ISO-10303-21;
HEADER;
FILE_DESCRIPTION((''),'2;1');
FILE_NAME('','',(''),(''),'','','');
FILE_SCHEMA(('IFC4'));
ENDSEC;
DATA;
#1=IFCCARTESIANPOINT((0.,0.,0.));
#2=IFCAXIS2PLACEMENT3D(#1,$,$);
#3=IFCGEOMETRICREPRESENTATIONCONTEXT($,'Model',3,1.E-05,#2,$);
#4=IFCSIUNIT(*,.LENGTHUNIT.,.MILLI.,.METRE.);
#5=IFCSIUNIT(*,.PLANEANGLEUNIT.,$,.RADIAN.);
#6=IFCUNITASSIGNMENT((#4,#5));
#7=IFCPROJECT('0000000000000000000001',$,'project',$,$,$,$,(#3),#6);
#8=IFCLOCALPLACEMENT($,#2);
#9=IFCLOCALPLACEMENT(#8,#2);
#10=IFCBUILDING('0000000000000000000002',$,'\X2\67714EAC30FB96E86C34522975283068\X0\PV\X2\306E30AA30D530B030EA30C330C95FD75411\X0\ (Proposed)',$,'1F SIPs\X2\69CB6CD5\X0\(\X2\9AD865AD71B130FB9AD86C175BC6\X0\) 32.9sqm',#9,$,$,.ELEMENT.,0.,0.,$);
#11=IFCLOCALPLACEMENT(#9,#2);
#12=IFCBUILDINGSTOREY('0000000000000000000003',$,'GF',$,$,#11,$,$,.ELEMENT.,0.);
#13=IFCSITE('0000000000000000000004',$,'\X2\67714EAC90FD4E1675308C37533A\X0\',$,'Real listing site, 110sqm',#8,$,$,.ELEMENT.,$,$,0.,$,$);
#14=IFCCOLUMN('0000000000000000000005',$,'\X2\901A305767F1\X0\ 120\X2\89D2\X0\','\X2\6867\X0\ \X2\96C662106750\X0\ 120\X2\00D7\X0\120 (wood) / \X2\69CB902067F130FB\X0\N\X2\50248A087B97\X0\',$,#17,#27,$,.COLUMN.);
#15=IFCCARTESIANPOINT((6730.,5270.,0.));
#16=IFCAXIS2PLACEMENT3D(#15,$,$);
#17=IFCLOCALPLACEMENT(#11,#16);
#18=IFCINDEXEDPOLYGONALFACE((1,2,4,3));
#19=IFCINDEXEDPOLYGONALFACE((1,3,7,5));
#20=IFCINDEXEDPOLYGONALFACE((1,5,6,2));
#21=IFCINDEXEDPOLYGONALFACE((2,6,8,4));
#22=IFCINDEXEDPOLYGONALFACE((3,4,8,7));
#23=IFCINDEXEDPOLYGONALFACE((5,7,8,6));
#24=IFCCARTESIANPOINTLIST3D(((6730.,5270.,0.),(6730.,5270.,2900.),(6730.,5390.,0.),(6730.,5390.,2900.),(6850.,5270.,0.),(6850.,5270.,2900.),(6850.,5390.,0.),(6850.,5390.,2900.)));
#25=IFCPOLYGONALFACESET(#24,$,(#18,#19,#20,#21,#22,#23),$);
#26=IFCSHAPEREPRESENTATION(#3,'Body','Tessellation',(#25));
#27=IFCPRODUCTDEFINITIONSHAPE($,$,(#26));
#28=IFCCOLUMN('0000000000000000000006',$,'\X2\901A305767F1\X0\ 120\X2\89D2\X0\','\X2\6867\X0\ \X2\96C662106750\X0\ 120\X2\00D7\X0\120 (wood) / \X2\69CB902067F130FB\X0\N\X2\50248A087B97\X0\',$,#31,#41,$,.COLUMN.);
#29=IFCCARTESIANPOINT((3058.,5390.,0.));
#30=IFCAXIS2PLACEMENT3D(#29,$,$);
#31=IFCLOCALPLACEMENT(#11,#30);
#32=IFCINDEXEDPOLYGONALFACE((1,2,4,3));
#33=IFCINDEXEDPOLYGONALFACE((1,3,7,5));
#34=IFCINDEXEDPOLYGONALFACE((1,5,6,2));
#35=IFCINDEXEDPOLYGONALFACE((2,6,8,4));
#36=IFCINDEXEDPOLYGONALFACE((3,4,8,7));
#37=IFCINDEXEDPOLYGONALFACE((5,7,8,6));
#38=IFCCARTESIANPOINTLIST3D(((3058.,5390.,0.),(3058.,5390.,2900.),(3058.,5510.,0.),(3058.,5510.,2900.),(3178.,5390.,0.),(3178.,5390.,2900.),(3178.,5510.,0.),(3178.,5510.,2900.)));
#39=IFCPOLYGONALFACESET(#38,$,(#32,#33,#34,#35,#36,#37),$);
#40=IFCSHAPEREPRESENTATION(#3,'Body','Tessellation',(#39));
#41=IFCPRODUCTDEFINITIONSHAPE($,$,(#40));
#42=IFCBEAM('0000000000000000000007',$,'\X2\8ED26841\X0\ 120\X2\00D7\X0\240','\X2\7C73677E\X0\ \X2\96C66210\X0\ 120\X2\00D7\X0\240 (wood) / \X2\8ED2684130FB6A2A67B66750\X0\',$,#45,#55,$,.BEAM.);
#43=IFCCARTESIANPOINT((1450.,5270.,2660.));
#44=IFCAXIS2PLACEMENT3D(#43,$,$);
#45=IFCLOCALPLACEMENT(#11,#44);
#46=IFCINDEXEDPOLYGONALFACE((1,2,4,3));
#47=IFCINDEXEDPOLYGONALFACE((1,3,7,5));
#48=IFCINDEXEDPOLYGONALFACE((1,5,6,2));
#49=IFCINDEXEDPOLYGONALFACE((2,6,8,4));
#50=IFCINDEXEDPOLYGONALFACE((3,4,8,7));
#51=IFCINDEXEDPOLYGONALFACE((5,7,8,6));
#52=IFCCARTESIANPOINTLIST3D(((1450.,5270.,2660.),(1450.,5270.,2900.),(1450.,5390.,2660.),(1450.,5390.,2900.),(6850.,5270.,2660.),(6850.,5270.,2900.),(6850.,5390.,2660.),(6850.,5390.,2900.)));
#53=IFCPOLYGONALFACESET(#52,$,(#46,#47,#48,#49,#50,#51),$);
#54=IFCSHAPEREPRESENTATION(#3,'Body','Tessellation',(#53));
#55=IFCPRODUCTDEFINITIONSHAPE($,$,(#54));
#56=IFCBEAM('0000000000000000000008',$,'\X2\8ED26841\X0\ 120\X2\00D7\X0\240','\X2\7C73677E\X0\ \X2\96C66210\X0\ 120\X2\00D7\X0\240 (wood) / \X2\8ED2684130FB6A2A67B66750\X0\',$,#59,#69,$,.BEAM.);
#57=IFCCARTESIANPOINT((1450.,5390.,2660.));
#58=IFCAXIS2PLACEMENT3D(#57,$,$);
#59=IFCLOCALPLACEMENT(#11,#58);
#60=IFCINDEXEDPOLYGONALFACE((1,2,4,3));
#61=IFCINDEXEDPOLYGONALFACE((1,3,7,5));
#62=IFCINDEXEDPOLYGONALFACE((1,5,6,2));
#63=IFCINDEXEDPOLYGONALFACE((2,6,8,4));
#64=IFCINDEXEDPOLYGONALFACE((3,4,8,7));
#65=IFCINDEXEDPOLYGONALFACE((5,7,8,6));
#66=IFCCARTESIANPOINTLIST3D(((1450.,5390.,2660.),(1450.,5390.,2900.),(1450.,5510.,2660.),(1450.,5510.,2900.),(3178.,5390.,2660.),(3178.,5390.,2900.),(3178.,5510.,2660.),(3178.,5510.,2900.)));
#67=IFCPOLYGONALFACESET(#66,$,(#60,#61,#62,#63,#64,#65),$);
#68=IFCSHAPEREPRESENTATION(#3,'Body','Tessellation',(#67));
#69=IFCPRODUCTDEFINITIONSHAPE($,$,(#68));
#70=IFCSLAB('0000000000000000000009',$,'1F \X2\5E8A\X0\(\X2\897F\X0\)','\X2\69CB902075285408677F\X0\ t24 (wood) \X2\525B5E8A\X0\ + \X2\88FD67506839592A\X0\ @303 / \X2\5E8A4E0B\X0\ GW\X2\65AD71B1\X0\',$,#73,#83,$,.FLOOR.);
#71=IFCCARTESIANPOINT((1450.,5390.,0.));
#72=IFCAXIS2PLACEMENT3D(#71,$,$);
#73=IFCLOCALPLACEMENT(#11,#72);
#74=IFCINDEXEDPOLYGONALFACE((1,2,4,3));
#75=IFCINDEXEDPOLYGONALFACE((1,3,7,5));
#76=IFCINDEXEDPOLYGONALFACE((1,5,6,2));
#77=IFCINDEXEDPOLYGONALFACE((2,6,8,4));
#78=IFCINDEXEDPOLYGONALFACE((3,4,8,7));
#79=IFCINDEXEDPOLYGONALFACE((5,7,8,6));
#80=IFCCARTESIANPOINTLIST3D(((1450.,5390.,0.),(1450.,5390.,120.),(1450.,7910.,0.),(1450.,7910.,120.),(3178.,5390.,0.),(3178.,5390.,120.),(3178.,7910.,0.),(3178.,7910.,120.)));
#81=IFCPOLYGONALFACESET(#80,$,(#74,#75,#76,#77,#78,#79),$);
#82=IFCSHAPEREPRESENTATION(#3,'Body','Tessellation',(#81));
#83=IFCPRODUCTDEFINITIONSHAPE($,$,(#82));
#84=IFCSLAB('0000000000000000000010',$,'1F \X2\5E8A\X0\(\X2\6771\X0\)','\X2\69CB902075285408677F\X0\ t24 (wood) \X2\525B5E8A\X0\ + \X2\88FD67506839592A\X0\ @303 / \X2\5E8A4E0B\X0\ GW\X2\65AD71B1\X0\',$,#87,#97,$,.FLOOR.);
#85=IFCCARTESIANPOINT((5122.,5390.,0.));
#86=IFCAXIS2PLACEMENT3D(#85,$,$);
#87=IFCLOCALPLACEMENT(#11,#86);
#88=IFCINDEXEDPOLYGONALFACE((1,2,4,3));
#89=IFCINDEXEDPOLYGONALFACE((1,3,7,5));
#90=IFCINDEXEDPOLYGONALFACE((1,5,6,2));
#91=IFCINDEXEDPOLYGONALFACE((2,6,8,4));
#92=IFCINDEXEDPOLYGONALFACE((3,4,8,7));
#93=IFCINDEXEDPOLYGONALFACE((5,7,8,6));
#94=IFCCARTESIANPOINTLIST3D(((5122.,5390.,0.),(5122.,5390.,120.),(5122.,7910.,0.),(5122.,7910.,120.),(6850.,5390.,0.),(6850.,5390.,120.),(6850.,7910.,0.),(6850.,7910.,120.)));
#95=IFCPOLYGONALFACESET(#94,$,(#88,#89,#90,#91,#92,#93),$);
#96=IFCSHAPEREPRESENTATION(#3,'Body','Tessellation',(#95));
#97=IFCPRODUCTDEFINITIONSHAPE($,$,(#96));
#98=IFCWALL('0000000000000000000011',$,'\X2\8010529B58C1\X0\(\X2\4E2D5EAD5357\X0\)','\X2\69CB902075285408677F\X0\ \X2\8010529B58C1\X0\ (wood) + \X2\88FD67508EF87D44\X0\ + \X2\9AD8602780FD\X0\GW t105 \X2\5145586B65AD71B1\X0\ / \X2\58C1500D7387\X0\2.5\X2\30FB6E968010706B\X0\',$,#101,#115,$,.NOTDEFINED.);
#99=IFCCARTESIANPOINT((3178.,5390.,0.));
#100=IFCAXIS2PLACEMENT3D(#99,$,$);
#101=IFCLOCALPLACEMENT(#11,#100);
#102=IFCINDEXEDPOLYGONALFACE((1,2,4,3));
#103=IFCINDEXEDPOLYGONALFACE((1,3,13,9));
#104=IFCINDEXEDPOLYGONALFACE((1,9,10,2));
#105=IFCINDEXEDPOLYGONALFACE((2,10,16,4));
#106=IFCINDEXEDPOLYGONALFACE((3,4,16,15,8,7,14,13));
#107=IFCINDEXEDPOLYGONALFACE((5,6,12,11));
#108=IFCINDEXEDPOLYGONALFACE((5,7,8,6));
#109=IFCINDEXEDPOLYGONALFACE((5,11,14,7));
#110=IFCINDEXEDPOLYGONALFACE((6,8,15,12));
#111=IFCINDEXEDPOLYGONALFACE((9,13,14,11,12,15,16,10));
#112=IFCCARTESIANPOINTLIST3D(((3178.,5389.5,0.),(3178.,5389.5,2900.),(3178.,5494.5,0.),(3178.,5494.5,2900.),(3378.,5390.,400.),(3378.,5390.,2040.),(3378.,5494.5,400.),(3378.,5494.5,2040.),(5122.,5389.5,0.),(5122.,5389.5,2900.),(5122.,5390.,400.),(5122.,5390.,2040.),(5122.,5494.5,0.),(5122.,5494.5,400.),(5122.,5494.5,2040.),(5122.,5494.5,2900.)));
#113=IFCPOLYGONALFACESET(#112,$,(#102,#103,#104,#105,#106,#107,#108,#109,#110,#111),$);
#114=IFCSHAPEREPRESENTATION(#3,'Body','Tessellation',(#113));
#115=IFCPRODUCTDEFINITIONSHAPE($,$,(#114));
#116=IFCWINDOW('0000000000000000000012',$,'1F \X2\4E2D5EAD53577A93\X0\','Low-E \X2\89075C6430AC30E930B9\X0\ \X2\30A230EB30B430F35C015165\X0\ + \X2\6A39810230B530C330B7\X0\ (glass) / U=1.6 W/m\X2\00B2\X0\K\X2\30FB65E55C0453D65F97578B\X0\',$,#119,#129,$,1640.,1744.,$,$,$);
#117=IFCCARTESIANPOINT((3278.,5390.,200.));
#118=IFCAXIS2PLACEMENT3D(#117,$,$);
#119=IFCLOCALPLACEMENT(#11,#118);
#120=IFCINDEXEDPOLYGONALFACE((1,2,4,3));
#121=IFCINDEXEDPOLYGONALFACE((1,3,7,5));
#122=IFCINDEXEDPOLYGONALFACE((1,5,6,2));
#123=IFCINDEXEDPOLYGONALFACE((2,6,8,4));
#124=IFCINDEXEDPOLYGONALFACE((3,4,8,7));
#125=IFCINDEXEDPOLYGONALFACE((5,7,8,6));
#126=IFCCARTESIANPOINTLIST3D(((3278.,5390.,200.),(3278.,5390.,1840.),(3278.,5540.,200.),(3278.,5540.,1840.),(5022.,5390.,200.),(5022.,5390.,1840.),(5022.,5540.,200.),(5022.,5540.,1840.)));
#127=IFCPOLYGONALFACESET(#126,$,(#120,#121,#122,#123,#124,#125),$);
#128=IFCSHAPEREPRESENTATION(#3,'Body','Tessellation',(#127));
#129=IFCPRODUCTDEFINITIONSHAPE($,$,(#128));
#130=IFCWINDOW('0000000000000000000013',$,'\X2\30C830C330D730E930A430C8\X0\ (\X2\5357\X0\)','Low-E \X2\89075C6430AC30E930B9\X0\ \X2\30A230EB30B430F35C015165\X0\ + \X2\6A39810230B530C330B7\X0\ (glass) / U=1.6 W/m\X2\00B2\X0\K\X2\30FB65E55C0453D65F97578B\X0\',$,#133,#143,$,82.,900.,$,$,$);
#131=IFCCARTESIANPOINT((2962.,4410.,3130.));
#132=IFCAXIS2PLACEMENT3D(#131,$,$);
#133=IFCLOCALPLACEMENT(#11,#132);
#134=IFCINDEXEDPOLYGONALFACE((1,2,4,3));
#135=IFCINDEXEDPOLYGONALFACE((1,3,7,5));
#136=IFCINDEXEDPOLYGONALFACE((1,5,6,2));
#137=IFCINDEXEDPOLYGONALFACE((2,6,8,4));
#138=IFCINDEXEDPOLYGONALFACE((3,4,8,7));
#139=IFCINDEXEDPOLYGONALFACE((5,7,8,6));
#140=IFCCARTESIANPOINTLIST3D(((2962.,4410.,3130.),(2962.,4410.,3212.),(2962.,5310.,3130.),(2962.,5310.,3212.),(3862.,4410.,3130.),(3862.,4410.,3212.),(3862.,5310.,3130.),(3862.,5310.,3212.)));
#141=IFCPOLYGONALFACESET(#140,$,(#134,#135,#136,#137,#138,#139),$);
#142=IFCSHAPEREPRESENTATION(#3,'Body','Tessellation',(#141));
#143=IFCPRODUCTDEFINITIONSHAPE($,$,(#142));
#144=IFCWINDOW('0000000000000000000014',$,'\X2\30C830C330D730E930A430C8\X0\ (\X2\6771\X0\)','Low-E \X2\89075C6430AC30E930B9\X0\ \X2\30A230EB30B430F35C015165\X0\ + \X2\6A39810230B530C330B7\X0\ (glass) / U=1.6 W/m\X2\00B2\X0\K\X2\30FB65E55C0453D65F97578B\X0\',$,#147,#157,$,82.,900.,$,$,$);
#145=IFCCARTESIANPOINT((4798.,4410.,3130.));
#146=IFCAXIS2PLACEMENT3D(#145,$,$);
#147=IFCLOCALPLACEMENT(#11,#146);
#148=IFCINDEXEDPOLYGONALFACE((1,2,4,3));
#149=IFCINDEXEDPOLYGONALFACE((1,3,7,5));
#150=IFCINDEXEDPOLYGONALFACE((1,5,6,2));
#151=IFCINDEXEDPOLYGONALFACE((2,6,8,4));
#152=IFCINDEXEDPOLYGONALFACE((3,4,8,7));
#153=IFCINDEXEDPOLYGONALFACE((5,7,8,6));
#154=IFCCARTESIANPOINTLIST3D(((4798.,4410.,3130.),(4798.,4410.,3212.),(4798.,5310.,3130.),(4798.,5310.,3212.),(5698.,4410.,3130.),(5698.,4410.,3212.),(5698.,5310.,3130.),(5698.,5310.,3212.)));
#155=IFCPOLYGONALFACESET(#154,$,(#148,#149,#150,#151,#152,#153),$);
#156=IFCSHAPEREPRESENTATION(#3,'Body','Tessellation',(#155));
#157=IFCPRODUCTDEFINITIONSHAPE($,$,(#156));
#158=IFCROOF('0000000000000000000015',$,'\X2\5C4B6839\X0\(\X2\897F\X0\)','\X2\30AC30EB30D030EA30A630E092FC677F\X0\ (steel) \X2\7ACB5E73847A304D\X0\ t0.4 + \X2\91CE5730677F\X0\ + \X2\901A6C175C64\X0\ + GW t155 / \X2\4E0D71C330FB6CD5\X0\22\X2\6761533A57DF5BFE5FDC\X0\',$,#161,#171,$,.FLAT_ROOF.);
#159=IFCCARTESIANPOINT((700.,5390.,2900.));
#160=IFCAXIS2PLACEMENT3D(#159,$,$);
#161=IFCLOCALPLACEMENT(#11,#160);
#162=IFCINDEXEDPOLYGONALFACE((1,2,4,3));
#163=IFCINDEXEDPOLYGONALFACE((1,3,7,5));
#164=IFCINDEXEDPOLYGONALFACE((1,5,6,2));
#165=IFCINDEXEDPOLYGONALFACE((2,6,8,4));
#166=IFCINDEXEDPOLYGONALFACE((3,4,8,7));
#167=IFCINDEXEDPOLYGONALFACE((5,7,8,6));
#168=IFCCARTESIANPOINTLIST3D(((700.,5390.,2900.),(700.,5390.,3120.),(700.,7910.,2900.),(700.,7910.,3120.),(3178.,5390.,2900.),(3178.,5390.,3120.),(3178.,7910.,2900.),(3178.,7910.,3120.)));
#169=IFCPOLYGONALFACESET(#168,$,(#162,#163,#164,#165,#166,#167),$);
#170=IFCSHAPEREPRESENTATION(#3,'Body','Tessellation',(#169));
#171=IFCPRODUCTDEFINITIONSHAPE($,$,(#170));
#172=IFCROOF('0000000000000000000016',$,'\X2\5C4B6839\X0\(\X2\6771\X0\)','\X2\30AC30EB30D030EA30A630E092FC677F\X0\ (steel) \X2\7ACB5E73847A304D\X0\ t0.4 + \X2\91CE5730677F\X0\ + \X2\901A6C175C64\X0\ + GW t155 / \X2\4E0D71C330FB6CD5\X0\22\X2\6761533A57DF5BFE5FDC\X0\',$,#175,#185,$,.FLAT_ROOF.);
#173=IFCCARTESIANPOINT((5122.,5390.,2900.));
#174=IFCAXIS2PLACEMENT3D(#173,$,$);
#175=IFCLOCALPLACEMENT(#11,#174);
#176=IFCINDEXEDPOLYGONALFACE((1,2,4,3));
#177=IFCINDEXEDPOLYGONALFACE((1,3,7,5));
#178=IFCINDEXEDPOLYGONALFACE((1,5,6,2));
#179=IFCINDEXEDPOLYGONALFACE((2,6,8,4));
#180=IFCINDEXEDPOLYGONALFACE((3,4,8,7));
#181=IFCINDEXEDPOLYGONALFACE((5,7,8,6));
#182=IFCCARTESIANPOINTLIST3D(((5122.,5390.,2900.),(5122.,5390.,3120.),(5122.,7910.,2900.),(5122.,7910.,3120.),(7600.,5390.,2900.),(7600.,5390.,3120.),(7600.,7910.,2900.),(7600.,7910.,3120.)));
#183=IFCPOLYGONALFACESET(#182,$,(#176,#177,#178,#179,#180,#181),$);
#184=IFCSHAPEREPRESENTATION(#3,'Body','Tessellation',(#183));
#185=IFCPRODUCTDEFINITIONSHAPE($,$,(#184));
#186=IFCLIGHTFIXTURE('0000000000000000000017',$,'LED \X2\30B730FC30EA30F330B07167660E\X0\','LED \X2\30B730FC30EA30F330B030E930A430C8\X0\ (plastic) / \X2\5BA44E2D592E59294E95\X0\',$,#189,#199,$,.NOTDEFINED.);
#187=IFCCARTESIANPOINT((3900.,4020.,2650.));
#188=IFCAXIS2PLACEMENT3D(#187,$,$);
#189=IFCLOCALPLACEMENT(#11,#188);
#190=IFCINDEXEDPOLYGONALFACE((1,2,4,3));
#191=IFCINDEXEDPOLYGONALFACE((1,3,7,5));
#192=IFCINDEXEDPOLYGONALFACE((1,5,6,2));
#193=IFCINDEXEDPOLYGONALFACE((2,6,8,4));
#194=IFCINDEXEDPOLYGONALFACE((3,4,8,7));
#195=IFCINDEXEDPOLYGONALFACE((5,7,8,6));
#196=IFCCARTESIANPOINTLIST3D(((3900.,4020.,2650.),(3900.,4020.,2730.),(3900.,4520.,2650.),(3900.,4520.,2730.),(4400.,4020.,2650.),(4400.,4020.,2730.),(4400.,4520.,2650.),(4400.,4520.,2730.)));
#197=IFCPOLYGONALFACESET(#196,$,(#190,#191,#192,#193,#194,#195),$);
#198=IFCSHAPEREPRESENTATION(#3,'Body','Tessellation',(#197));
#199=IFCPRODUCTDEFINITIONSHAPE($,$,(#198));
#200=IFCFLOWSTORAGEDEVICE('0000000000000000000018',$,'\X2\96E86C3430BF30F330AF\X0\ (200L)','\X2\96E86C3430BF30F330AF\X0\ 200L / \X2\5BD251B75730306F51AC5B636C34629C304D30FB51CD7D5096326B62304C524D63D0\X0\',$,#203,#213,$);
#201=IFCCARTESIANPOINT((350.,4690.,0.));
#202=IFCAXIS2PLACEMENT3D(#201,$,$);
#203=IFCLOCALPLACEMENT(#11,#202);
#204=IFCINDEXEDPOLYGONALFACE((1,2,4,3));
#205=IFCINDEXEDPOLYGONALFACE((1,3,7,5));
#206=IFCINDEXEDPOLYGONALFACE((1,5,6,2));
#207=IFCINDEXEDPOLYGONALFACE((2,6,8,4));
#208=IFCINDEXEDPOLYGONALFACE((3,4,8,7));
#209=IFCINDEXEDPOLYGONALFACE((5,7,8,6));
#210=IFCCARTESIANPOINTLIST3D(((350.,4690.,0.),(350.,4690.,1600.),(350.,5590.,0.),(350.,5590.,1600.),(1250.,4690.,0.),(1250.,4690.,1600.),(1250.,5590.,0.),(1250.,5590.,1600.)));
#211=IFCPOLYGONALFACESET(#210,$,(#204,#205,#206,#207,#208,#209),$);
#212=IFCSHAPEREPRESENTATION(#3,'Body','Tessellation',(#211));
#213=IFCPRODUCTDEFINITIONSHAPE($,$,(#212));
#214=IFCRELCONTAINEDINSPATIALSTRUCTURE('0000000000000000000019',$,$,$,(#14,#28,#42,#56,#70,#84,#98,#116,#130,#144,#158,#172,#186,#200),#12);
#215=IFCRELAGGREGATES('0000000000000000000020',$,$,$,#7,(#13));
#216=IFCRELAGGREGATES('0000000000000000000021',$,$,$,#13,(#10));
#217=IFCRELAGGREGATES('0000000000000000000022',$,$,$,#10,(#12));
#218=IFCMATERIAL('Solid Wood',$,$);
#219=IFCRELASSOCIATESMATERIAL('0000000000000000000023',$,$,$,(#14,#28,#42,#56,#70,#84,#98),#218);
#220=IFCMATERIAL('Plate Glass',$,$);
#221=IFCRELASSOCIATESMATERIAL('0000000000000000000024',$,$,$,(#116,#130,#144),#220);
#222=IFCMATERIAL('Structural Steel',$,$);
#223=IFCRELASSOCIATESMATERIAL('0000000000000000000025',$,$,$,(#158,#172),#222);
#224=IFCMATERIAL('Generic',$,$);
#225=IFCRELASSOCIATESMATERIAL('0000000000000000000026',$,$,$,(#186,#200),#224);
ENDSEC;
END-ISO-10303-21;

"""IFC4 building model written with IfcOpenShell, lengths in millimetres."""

from ifc_helpers import new_model, si_unit, frame, frame_2d, origin, place, context, project, spatial, rectangle, extrude, material, element, fill, save


model = new_model("IFC4")

# Units and contexts
model_context = context("Model", 3, precision=1e-05, world=origin())
ifc_project = project(units=[si_unit("LENGTHUNIT", "METRE", prefix="MILLI"), si_unit("PLANEANGLEUNIT", "RADIAN")], contexts=[model_context])

# Site, building, storey
site_placement = place(None, origin())
site = spatial("IfcSite", under=ifc_project, at=site_placement, Name="東京都世田谷区", ObjectType="Real listing site, 110sqm", CompositionType="ELEMENT", RefElevation=0.0)
building_placement = place(site_placement, origin())
building = spatial("IfcBuilding", under=site, at=building_placement, Name="東京・雨水利用とPVのオフグリッド志向 (Proposed)", ObjectType="1F SIPs構法(高断熱・高気密) 32.9sqm", CompositionType="ELEMENT", ElevationOfRefHeight=0.0, ElevationOfTerrain=0.0)
storey_placement = place(building_placement, origin())
storey = spatial("IfcBuildingStorey", under=building, at=storey_placement, Name="GF", CompositionType="ELEMENT", Elevation=0.0)

# Columns
ifc_material_1 = material(Name="Solid Wood")
column_1_placement = place(storey_placement, frame((6730.0, 5270.0, 0.0)))
element("IfcColumn", 1, at=column_1_placement, inside=storey, material=ifc_material_1, Name="通し柱 120角", Description="桧 集成材 120×120 (wood) / 構造柱・N値計算", PredefinedType="COLUMN", context=model_context, shape_type="SweptSolid", body=[
    extrude(rectangle(XDim=120.0, YDim=120.0, at=frame_2d((60.0, 60.0))), frame((6730.0, 5270.0, 0.0)), (0.0, 0.0, 1.0), 2900.0),
])
column_2_placement = place(storey_placement, frame((3058.0, 5390.0, 0.0)))
element("IfcColumn", 2, at=column_2_placement, inside=storey, material=ifc_material_1, Name="通し柱 120角", Description="桧 集成材 120×120 (wood) / 構造柱・N値計算", PredefinedType="COLUMN", context=model_context, shape_type="SweptSolid", body=[
    extrude(rectangle(XDim=120.0, YDim=120.0, at=frame_2d((60.0, 60.0))), frame((3058.0, 5390.0, 0.0)), (0.0, 0.0, 1.0), 2900.0),
])

# Beams
beam_1_placement = place(storey_placement, frame((1450.0, 5270.0, 2660.0)))
element("IfcBeam", 3, at=beam_1_placement, inside=storey, material=ifc_material_1, Name="軒桁 120×240", Description="米松 集成 120×240 (wood) / 軒桁・横架材", PredefinedType="BEAM", context=model_context, shape_type="SweptSolid", body=[
    extrude(rectangle(XDim=5400.0, YDim=120.0, at=frame_2d((2700.0, 60.0))), frame((1450.0, 5270.0, 2660.0)), (0.0, 0.0, 1.0), 240.0),
])
beam_2_placement = place(storey_placement, frame((1450.0, 5390.0, 2660.0)))
element("IfcBeam", 4, at=beam_2_placement, inside=storey, material=ifc_material_1, Name="軒桁 120×240", Description="米松 集成 120×240 (wood) / 軒桁・横架材", PredefinedType="BEAM", context=model_context, shape_type="SweptSolid", body=[
    extrude(rectangle(XDim=1728.0, YDim=120.0, at=frame_2d((864.0, 60.0))), frame((1450.0, 5390.0, 2660.0)), (0.0, 0.0, 1.0), 240.0),
])

# Slabs
slab_1_placement = place(storey_placement, frame((1450.0, 5390.0, 0.0)))
element("IfcSlab", 5, at=slab_1_placement, inside=storey, material=ifc_material_1, Name="1F 床(西)", Description="構造用合板 t24 (wood) 剛床 + 製材根太 @303 / 床下 GW断熱", PredefinedType="FLOOR", context=model_context, shape_type="SweptSolid", body=[
    extrude(rectangle(XDim=1728.0, YDim=2520.0, at=frame_2d((864.0, 1260.0))), frame((1450.0, 5390.0, 0.0)), (0.0, 0.0, 1.0), 120.0),
])
slab_2_placement = place(storey_placement, frame((5122.0, 5390.0, 0.0)))
element("IfcSlab", 6, at=slab_2_placement, inside=storey, material=ifc_material_1, Name="1F 床(東)", Description="構造用合板 t24 (wood) 剛床 + 製材根太 @303 / 床下 GW断熱", PredefinedType="FLOOR", context=model_context, shape_type="SweptSolid", body=[
    extrude(rectangle(XDim=1728.0, YDim=2520.0, at=frame_2d((864.0, 1260.0))), frame((5122.0, 5390.0, 0.0)), (0.0, 0.0, 1.0), 120.0),
])

# Wall, opening, window
wall_1_placement = place(storey_placement, frame((3178.0, 5390.0, 0.0)))
wall_1 = element("IfcWall", 7, at=wall_1_placement, inside=storey, material=ifc_material_1, Name="耐力壁(中庭南)", Description="構造用合板 耐力壁 (wood) + 製材軸組 + 高性能GW t105 充填断熱 / 壁倍率2.5・準耐火", PredefinedType="NOTDEFINED", context=model_context, shape_type="SweptSolid", body=[
    extrude(rectangle(XDim=1944.0, YDim=105.0, at=frame_2d((972.0, 52.0))), frame((3178.0, 5390.0, 0.0)), (0.0, 0.0, 1.0), 2900.0),
])
opening_placement = place(storey_placement, frame((3278.0, 5390.0, 200.0)))
opening = element("IfcOpeningElement", 8, at=opening_placement, cuts=wall_1, PredefinedType="NOTDEFINED", context=model_context, shape_type="SweptSolid", body=[
    extrude(rectangle(XDim=1744.0, YDim=150.0, at=frame_2d((872.0, 75.0))), frame((3278.0, 5390.0, 200.0)), (0.0, 0.0, 1.0), 1640.0),
])
ifc_material_2 = material(Name="Plate Glass")
window_1_placement = place(storey_placement, frame((3278.0, 5390.0, 200.0)))
window_1 = element("IfcWindow", 9, at=window_1_placement, inside=storey, material=ifc_material_2, Name="1F 中庭南窓", Description="Low-E 複層ガラス アルゴン封入 + 樹脂サッシ (glass) / U=1.6 W/m²K・日射取得型", OverallHeight=1640.0, OverallWidth=1744.0, context=model_context, shape_type="SweptSolid", body=[
    extrude(rectangle(XDim=1744.0, YDim=150.0, at=frame_2d((872.0, 75.0))), frame((3278.0, 5390.0, 200.0)), (0.0, 0.0, 1.0), 1640.0),
])
fill(opening, window_1)

# Windows
window_2_placement = place(storey_placement, frame((2962.0, 4410.0, 3130.0)))
element("IfcWindow", 10, at=window_2_placement, inside=storey, material=ifc_material_2, Name="トップライト (南)", Description="Low-E 複層ガラス アルゴン封入 + 樹脂サッシ (glass) / U=1.6 W/m²K・日射取得型", OverallHeight=82.0, OverallWidth=900.0, context=model_context, shape_type="SweptSolid", body=[
    extrude(rectangle(XDim=900.0, YDim=900.0, at=frame_2d((450.0, 450.0))), frame((2962.0, 4410.0, 3130.0)), (0.0, 0.0, 1.0), 82.0),
])
window_3_placement = place(storey_placement, frame((4798.0, 4410.0, 3130.0)))
element("IfcWindow", 11, at=window_3_placement, inside=storey, material=ifc_material_2, Name="トップライト (東)", Description="Low-E 複層ガラス アルゴン封入 + 樹脂サッシ (glass) / U=1.6 W/m²K・日射取得型", OverallHeight=82.0, OverallWidth=900.0, context=model_context, shape_type="SweptSolid", body=[
    extrude(rectangle(XDim=900.0, YDim=900.0, at=frame_2d((450.0, 450.0))), frame((4798.0, 4410.0, 3130.0)), (0.0, 0.0, 1.0), 82.0),
])

# Roofs
ifc_material_3 = material(Name="Structural Steel")
roof_1_placement = place(storey_placement, frame((700.0, 5390.0, 2900.0)))
element("IfcRoof", 12, at=roof_1_placement, inside=storey, material=ifc_material_3, Name="屋根(西)", Description="ガルバリウム鋼板 (steel) 立平葺き t0.4 + 野地板 + 通気層 + GW t155 / 不燃・法22条区域対応", PredefinedType="FLAT_ROOF", context=model_context, shape_type="SweptSolid", body=[
    extrude(rectangle(XDim=2478.0, YDim=2520.0, at=frame_2d((1239.0, 1260.0))), frame((700.0, 5390.0, 2900.0)), (0.0, 0.0, 1.0), 220.0),
])
roof_2_placement = place(storey_placement, frame((5122.0, 5390.0, 2900.0)))
element("IfcRoof", 13, at=roof_2_placement, inside=storey, material=ifc_material_3, Name="屋根(東)", Description="ガルバリウム鋼板 (steel) 立平葺き t0.4 + 野地板 + 通気層 + GW t155 / 不燃・法22条区域対応", PredefinedType="FLAT_ROOF", context=model_context, shape_type="SweptSolid", body=[
    extrude(rectangle(XDim=2478.0, YDim=2520.0, at=frame_2d((1239.0, 1260.0))), frame((5122.0, 5390.0, 2900.0)), (0.0, 0.0, 1.0), 220.0),
])

# Light fixture
ifc_material_4 = material(Name="Generic")
light_fixture_placement = place(storey_placement, frame((3900.0, 4020.0, 2650.0)))
element("IfcLightFixture", 14, at=light_fixture_placement, inside=storey, material=ifc_material_4, Name="LED シーリング照明", Description="LED シーリングライト (plastic) / 室中央天井", PredefinedType="NOTDEFINED", context=model_context, shape_type="SweptSolid", body=[
    extrude(rectangle(XDim=500.0, YDim=500.0, at=frame_2d((250.0, 250.0))), frame((3900.0, 4020.0, 2650.0)), (0.0, 0.0, 1.0), 80.0),
])

# Flow storage device
flow_storage_device_placement = place(storey_placement, frame((350.0, 4690.0, 0.0)))
element("IfcFlowStorageDevice", 15, at=flow_storage_device_placement, inside=storey, material=ifc_material_4, Name="雨水タンク (200L)", Description="雨水タンク 200L / 寒冷地は冬季水抜き・凍結防止が前提", context=model_context, shape_type="SweptSolid", body=[
    extrude(rectangle(XDim=900.0, YDim=900.0, at=frame_2d((450.0, 450.0))), frame((350.0, 4690.0, 0.0)), (0.0, 0.0, 1.0), 1600.0),
])

save(model, "model.ifc")
